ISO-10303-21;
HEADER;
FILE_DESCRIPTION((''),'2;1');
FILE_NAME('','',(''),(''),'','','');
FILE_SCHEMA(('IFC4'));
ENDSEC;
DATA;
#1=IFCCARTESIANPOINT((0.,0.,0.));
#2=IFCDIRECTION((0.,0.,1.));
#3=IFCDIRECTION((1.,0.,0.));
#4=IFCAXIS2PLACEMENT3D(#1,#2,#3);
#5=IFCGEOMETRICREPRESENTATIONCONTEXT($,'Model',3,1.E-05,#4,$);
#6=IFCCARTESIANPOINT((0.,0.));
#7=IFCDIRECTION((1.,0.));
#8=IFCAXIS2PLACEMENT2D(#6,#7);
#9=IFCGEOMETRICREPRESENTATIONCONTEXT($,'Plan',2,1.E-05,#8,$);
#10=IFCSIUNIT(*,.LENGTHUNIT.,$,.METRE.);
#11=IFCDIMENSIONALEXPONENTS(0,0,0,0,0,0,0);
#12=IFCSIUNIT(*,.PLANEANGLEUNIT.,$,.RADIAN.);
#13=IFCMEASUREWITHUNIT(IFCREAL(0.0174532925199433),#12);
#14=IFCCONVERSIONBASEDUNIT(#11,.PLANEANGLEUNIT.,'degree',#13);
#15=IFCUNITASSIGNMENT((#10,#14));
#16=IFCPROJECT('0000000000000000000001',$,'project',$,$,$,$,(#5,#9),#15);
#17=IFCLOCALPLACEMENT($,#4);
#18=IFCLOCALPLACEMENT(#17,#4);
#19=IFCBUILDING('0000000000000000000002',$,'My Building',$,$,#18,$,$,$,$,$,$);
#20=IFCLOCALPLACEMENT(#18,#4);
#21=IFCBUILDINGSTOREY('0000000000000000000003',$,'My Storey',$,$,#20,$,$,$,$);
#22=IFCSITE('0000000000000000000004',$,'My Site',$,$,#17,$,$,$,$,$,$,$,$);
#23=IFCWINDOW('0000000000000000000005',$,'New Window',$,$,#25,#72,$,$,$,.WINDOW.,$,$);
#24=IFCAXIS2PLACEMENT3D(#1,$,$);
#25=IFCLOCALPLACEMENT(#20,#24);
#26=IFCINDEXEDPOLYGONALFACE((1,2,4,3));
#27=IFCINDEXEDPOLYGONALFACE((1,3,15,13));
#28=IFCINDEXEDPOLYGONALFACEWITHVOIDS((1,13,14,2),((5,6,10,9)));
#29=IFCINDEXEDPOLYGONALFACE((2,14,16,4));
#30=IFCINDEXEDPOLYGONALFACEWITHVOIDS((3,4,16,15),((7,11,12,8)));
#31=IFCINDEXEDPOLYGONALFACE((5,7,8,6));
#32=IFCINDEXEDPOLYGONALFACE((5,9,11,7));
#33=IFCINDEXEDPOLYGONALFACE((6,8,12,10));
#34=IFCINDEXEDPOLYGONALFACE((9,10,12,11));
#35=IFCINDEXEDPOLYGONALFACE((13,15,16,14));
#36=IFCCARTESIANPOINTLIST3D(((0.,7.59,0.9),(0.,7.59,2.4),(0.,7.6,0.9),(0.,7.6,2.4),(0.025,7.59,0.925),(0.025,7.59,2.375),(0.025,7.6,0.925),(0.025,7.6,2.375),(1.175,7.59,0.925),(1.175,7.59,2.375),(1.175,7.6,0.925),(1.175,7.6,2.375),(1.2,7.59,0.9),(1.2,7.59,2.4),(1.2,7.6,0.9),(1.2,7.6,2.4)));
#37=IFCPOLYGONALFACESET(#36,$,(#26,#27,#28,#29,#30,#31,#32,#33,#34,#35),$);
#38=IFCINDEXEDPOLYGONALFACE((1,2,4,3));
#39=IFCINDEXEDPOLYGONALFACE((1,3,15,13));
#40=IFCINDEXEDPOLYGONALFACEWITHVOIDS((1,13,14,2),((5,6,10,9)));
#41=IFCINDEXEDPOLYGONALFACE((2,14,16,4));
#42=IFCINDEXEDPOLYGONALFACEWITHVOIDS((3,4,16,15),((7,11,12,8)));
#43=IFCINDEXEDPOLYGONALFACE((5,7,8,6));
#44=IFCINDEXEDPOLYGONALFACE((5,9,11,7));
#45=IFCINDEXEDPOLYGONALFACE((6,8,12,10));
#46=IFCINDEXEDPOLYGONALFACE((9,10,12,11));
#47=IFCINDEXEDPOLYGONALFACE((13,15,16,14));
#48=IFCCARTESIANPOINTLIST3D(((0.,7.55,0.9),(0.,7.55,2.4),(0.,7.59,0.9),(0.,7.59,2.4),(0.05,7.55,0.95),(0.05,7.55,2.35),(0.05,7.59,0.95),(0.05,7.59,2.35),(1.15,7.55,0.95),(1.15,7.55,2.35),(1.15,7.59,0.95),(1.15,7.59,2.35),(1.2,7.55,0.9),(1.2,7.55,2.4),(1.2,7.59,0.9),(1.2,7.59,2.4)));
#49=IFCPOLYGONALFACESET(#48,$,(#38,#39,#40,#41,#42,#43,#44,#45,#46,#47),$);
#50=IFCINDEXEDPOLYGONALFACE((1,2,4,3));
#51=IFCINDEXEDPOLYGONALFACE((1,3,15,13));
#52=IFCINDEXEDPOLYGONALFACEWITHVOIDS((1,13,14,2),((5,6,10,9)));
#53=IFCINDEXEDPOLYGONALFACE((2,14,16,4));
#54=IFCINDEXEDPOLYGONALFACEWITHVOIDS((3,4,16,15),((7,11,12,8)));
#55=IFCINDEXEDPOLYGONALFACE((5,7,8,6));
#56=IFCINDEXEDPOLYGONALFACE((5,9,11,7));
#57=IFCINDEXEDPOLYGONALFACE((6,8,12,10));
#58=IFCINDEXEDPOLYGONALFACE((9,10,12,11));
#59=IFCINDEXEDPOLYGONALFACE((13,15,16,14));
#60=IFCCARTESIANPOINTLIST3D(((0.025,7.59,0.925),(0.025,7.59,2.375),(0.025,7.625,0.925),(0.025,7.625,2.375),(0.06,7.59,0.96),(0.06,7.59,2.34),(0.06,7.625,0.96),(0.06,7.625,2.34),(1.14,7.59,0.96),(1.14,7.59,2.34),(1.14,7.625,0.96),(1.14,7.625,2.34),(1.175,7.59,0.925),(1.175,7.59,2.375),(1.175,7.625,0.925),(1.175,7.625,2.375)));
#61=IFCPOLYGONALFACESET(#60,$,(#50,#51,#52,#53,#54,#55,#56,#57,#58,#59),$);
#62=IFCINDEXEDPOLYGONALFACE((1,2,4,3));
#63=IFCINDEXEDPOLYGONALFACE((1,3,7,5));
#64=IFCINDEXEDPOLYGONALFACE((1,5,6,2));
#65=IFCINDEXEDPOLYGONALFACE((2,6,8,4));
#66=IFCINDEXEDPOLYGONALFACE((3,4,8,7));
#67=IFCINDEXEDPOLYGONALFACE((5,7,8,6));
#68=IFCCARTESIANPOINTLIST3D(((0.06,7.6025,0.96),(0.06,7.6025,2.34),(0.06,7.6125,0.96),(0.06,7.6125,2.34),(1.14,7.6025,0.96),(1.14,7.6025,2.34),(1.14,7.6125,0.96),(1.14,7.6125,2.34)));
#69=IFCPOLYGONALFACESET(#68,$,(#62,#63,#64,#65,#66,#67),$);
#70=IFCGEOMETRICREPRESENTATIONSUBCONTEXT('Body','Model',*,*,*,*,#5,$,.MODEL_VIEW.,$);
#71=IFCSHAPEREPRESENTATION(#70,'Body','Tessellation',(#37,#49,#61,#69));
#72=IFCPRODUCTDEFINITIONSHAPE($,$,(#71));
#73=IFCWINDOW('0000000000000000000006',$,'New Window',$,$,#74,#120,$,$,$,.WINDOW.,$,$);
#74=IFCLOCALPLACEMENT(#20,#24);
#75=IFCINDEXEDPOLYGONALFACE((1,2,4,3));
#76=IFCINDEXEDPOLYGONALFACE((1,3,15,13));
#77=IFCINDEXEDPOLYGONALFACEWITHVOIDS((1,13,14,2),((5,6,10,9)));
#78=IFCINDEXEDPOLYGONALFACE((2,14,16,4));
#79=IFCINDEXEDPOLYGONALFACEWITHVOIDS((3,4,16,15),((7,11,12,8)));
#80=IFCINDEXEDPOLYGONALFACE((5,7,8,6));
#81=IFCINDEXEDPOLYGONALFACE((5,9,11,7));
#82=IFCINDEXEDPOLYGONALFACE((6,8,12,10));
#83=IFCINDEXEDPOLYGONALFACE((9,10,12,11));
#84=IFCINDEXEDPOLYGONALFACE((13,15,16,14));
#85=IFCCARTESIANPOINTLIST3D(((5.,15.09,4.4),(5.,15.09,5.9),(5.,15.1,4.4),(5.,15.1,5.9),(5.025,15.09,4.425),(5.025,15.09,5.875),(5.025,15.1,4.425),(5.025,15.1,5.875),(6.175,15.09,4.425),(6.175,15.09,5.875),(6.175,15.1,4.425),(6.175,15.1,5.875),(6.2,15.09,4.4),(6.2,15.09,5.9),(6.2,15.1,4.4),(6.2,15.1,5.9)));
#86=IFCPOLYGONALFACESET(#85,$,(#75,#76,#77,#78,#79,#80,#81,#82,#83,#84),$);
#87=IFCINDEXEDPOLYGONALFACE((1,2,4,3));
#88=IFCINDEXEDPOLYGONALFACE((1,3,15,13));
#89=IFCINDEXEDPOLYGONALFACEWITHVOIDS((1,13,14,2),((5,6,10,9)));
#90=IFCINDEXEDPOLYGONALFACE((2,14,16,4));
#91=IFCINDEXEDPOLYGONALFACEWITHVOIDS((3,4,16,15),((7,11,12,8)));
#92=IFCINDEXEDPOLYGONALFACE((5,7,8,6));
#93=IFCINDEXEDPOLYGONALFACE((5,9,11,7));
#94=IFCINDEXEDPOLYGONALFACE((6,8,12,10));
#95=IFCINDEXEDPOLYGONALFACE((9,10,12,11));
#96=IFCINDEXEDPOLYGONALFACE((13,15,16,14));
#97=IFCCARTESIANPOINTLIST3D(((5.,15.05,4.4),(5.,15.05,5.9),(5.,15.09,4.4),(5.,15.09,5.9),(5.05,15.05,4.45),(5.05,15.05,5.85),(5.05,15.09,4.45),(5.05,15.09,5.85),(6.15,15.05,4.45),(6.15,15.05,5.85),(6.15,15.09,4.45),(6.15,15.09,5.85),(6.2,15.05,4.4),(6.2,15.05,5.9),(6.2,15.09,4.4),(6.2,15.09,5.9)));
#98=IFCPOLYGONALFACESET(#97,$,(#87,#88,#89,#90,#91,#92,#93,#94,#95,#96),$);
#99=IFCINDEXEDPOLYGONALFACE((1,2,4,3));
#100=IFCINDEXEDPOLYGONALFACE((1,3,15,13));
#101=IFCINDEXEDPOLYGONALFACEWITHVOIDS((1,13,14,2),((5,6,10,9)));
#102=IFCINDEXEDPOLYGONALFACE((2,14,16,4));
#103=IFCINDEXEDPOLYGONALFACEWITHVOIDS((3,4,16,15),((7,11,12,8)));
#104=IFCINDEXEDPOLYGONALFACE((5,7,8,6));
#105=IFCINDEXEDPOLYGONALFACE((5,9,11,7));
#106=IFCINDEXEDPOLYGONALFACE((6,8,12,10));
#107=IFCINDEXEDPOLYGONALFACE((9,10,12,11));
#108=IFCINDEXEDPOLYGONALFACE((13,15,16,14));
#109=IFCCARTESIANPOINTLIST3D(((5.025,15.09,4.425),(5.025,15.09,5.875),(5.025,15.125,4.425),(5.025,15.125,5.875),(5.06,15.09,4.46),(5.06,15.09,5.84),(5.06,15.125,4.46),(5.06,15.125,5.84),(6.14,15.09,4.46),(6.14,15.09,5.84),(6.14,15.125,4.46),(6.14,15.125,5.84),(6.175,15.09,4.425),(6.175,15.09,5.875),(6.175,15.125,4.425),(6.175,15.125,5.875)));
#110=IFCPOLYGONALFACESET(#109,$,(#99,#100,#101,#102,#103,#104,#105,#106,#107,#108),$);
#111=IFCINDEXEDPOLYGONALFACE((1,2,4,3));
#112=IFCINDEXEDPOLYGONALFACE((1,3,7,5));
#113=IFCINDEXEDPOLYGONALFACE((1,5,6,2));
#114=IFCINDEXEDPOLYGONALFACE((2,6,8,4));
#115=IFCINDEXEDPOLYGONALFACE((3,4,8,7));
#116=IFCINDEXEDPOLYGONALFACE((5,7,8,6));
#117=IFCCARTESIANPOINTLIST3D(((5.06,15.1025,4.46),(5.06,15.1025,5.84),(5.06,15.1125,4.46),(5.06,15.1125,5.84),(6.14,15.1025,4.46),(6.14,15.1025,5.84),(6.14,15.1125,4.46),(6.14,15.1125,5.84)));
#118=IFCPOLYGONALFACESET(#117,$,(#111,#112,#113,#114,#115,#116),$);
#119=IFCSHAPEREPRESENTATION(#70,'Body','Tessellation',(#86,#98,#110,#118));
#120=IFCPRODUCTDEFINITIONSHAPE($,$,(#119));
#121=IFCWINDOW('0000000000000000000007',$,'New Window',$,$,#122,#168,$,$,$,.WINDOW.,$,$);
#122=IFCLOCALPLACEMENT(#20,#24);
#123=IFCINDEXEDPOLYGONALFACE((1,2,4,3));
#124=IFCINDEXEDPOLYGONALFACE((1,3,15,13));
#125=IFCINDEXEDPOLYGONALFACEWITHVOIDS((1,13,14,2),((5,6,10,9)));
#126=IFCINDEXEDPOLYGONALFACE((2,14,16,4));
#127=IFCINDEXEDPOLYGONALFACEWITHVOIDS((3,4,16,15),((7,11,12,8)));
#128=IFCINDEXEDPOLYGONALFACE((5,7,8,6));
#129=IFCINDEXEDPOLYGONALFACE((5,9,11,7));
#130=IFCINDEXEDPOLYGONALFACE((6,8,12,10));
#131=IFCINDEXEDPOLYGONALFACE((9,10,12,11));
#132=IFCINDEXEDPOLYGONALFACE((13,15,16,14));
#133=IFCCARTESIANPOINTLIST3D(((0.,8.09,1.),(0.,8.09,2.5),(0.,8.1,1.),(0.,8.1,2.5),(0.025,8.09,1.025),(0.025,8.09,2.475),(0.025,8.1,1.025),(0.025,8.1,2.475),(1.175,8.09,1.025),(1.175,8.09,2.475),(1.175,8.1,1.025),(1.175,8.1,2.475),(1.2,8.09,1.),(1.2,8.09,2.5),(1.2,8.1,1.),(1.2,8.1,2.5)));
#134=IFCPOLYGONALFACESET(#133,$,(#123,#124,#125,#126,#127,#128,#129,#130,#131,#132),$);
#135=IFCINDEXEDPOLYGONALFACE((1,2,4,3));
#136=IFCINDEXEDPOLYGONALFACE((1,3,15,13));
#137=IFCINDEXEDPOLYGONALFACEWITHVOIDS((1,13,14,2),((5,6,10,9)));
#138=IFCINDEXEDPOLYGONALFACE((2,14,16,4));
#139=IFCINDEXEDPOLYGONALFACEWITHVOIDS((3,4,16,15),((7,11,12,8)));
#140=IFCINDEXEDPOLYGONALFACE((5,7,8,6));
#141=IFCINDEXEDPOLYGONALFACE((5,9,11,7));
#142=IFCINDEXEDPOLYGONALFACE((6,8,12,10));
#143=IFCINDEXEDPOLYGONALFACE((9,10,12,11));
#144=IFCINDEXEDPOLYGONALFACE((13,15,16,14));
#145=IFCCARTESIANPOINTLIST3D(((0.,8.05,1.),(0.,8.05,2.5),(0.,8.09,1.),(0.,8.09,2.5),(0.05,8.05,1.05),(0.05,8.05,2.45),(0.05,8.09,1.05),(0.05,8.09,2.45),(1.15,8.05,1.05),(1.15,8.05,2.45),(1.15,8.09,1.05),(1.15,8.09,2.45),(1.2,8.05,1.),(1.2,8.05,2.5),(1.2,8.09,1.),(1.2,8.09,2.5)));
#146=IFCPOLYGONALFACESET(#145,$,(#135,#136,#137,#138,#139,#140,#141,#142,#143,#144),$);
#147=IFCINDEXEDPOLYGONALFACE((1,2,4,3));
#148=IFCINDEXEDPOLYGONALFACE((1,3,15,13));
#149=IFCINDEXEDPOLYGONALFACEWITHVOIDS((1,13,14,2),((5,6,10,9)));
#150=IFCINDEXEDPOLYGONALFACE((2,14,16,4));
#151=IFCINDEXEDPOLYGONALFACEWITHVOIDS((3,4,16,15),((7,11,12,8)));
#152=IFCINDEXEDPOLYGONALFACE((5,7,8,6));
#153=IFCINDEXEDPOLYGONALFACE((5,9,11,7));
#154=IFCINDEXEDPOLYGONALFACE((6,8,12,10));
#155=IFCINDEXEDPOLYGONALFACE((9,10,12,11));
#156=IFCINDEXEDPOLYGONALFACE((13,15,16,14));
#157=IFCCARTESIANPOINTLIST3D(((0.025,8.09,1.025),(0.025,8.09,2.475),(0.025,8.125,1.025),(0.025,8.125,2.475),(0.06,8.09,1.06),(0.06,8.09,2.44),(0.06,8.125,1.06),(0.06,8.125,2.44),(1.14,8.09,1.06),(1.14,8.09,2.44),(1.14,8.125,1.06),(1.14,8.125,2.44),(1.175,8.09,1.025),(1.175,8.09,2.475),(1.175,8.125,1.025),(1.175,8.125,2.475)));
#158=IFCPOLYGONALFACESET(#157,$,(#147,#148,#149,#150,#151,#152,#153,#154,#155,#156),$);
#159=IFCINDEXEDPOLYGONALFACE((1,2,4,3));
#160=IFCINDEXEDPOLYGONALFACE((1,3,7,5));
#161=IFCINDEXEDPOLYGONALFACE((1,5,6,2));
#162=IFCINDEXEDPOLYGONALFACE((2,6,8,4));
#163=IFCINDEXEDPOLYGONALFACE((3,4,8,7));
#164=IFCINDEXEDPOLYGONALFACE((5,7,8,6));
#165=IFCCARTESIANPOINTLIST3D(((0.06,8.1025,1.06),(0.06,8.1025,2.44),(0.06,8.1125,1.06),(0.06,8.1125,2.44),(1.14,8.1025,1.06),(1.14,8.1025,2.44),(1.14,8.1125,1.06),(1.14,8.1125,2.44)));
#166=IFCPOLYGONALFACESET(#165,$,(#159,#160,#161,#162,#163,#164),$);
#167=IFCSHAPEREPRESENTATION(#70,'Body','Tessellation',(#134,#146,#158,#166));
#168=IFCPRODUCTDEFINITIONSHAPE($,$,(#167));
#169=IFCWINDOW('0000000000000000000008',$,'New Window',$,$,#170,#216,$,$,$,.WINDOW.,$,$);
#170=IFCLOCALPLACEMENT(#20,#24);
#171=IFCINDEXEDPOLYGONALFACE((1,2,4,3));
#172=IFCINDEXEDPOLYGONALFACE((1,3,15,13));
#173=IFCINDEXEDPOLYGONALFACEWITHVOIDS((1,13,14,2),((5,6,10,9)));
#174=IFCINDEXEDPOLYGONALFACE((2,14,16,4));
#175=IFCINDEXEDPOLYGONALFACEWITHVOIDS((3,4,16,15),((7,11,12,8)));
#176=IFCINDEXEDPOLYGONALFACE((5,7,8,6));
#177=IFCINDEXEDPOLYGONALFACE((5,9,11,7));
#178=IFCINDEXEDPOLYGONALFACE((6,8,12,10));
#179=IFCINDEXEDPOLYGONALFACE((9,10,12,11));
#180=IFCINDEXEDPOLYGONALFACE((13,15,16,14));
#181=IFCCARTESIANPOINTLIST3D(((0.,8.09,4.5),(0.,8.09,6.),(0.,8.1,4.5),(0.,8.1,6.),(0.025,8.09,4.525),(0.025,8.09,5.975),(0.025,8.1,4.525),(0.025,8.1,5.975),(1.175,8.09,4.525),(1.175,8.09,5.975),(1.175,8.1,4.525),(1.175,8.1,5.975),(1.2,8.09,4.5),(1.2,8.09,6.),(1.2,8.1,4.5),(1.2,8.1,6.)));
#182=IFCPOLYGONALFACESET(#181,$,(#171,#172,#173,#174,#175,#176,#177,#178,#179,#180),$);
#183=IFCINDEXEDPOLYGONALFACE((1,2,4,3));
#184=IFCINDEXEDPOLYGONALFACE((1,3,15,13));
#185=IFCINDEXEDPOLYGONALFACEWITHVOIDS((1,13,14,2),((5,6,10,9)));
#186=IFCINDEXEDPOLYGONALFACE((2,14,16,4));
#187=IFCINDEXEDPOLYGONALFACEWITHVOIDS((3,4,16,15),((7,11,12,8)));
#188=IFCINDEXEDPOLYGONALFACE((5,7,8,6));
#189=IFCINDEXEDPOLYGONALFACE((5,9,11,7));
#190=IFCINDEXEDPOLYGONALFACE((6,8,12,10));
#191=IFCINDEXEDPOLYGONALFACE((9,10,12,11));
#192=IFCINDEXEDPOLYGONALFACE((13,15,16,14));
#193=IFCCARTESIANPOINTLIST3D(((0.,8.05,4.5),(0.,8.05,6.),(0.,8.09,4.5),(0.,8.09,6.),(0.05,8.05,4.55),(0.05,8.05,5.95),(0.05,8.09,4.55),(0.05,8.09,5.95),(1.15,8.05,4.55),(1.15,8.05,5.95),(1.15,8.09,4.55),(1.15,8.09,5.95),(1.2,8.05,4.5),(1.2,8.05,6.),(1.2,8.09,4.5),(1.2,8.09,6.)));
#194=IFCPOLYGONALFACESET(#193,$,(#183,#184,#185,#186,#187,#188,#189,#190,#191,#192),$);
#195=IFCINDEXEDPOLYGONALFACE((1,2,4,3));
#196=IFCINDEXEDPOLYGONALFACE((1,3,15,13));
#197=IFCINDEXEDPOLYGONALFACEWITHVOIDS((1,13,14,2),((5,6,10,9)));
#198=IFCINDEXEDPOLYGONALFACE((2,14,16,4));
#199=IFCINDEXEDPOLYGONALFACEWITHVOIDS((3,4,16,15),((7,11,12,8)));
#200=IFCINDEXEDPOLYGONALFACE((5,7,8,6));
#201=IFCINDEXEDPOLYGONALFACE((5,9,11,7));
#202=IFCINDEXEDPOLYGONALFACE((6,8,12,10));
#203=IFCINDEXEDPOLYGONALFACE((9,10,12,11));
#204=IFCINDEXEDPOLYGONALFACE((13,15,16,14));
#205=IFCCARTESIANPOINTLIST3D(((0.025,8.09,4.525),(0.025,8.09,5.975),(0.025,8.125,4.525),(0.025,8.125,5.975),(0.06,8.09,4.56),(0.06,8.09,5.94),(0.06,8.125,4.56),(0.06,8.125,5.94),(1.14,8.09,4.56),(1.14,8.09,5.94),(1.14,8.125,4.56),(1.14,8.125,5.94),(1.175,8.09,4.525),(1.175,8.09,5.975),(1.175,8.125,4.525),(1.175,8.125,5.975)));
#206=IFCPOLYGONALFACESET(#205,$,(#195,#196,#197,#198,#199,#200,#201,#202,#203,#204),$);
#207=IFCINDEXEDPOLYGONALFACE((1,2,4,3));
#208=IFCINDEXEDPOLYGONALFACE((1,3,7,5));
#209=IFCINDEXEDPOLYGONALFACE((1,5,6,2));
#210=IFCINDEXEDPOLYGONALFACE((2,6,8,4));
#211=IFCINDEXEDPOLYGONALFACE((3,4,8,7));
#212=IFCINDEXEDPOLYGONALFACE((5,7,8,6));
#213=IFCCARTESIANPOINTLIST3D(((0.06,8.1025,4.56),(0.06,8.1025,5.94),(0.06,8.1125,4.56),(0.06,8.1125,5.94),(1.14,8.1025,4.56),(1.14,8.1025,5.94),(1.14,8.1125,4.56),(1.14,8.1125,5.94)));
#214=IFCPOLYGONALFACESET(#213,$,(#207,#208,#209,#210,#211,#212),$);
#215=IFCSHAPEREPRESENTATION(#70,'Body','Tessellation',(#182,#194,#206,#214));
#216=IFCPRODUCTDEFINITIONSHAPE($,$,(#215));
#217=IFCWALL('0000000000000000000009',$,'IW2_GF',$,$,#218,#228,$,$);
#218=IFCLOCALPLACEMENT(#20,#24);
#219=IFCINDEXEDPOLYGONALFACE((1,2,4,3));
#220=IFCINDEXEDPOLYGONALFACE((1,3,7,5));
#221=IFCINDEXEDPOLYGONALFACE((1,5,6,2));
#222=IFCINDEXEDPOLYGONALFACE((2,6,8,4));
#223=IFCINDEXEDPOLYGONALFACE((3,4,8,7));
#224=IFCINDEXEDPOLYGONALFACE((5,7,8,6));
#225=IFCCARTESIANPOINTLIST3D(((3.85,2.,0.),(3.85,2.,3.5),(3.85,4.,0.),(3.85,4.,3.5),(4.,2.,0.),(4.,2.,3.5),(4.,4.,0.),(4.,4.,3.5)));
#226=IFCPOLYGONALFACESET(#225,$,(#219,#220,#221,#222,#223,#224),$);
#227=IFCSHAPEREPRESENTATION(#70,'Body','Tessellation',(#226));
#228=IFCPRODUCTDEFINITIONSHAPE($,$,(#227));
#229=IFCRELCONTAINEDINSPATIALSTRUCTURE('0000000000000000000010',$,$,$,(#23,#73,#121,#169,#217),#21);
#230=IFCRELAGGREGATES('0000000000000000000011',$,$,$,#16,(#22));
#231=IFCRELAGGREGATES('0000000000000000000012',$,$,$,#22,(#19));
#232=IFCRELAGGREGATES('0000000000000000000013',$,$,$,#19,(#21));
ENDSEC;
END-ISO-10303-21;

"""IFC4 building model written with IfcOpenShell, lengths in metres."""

from ifc_helpers import new_model, entity, si_unit, converted_unit, frame, origin_with_axes, origin_2d_with_axis, place, context, subcontext, project, spatial, line, indexed_curve, outline, extrude, element, save


model = new_model("IFC4")

# Units and contexts
model_context = context("Model", 3, precision=1e-05, world=origin_with_axes())
plan_context = context("Plan", 2, precision=1e-05, world=origin_2d_with_axis())
body_context = subcontext(model_context, "Body", "Model", "MODEL_VIEW")
ifc_project = project(units=[si_unit("LENGTHUNIT", "METRE"), converted_unit("PLANEANGLEUNIT", "degree", entity("IfcReal", 0.0174532925199433), si_unit("PLANEANGLEUNIT", "RADIAN"), dimensions=[0, 0, 0, 0, 0, 0, 0])], contexts=[model_context, plan_context])

# Site, building, storey
site_placement = place(None, origin_with_axes())
site = spatial("IfcSite", under=ifc_project, at=site_placement, Name="My Site")
building_placement = place(site_placement, origin_with_axes())
building = spatial("IfcBuilding", under=site, at=building_placement, Name="My Building")
storey_placement = place(building_placement, origin_with_axes())
storey = spatial("IfcBuildingStorey", under=building, at=storey_placement, Name="My Storey")

# Windows
for number, where, z_axis, x_axis, name in (
    (1, (0.0, 7.5, 0.9), (0.0, 0.0, 1.0), (1.0, 0.0, 0.0), "New Window"),
    (2, (5.0, 15.0, 4.4), (0.0, 0.0, 1.0), (1.0, 0.0, 0.0), "New Window"),
):
    element("IfcWindow", number, at=place(storey_placement, frame(where, z_axis=z_axis, x_axis=x_axis)), inside=storey, Name=name, PredefinedType="WINDOW", context=body_context, shape_type="SweptSolid", body=[
        extrude(outline(indexed_curve([(0.0, 0.0), (1.2, 0.0), (1.2, 1.5), (0.0, 1.5)], segments=[line(1, 2, 3, 4, 1)]), holes=[indexed_curve([(0.025, 0.025), (1.175, 0.025), (1.175, 1.475), (0.025, 1.475)], segments=[line(1, 2, 3, 4, 1)])]), frame((0.0, 0.09, 0.0), z_axis=(0.0, -1.0, 0.0), x_axis=(1.0, 0.0, 0.0)), (0.0, 0.0, -1.0), 0.01),
        extrude(outline(indexed_curve([(0.0, 0.0), (1.2, 0.0), (1.2, 1.5), (0.0, 1.5)], segments=[line(1, 2, 3, 4, 1)]), holes=[indexed_curve([(0.05, 0.05), (1.15, 0.05), (1.15, 1.45), (0.05, 1.45)], segments=[line(1, 2, 3, 4, 1)])]), frame((0.0, 0.05, 0.0), z_axis=(0.0, -1.0, 0.0), x_axis=(1.0, 0.0, 0.0)), (0.0, 0.0, -1.0), 0.04),
        extrude(outline(indexed_curve([(0.0, 0.0), (1.15, 0.0), (1.15, 1.45), (0.0, 1.45)], segments=[line(1, 2, 3, 4, 1)]), holes=[indexed_curve([(0.035, 0.035), (1.115, 0.035), (1.115, 1.415), (0.035, 1.415)], segments=[line(1, 2, 3, 4, 1)])]), frame((0.025, 0.09, 0.025), z_axis=(0.0, -1.0, 0.0), x_axis=(1.0, 0.0, 0.0)), (0.0, 0.0, -1.0), 0.035),
        extrude(outline(indexed_curve([(0.035, 0.035), (1.115, 0.035), (1.115, 1.415), (0.035, 1.415)], segments=[line(1, 2, 3, 4, 1)])), frame((0.025, 0.1025, 0.025), z_axis=(0.0, -1.0, 0.0), x_axis=(1.0, 0.0, 0.0)), (0.0, 0.0, -1.0), 0.01),
    ])

# Windows
for number, where, z_axis, x_axis, name in (
    (3, (0.0, 8.0, 1.0), (0.0, 0.0, 1.0), (1.0, 0.0, 0.0), "New Window"),
    (4, (0.0, 8.0, 4.5), (0.0, 0.0, 1.0), (1.0, 0.0, 0.0), "New Window"),
):
    element("IfcWindow", number, at=place(storey_placement, frame(where, z_axis=z_axis, x_axis=x_axis)), inside=storey, Name=name, PredefinedType="WINDOW", context=body_context, shape_type="SweptSolid", body=[
        extrude(outline(indexed_curve([(0.0, 0.0), (1.2, 0.0), (1.2, 1.5), (0.0, 1.5)], segments=[line(1, 2, 3, 4, 1)]), holes=[indexed_curve([(0.025, 0.025), (1.175, 0.025), (1.175, 1.475), (0.025, 1.475)], segments=[line(1, 2, 3, 4, 1)])]), frame((0.0, 0.09, 0.0), z_axis=(0.0, -1.0, 0.0), x_axis=(1.0, 0.0, 0.0)), (0.0, 0.0, -1.0), 0.01),
        extrude(outline(indexed_curve([(0.0, 0.0), (1.2, 0.0), (1.2, 1.5), (0.0, 1.5)], segments=[line(1, 2, 3, 4, 1)]), holes=[indexed_curve([(0.05, 0.05), (1.15, 0.05), (1.15, 1.45), (0.05, 1.45)], segments=[line(1, 2, 3, 4, 1)])]), frame((0.0, 0.05, 0.0), z_axis=(0.0, -1.0, 0.0), x_axis=(1.0, 0.0, 0.0)), (0.0, 0.0, -1.0), 0.04),
        extrude(outline(indexed_curve([(0.0, 0.0), (1.15, 0.0), (1.15, 1.45), (0.0, 1.45)], segments=[line(1, 2, 3, 4, 1)]), holes=[indexed_curve([(0.035, 0.035), (1.115, 0.035), (1.115, 1.415), (0.035, 1.415)], segments=[line(1, 2, 3, 4, 1)])]), frame((0.025, 0.09, 0.025), z_axis=(0.0, -1.0, 0.0), x_axis=(1.0, 0.0, 0.0)), (0.0, 0.0, -1.0), 0.035),
        extrude(outline(indexed_curve([(0.035, 0.035), (1.115, 0.035), (1.115, 1.415), (0.035, 1.415)], segments=[line(1, 2, 3, 4, 1)])), frame((0.025, 0.1025, 0.025), z_axis=(0.0, -1.0, 0.0), x_axis=(1.0, 0.0, 0.0)), (0.0, 0.0, -1.0), 0.01),
    ])

# Wall
for number, where, z_axis, x_axis, name in (
    (5, (4.0, 2.0, 0.0), (0.0, 0.0, 1.0), (0.0, 1.0, 0.0), "IW2_GF"),
):
    element("IfcWall", number, at=place(storey_placement, frame(where, z_axis=z_axis, x_axis=x_axis)), inside=storey, Name=name, context=body_context, shape_type="SweptSolid", body=[
        extrude(outline(indexed_curve([(0.0, 0.0), (0.0, 0.15), (2.0, 0.15), (2.0, 0.0), (0.0, 0.0)], self_intersect=False)), origin_with_axes(), (0.0, 0.0, 1.0), 3.5),
    ])

save(model, "model.ifc")
